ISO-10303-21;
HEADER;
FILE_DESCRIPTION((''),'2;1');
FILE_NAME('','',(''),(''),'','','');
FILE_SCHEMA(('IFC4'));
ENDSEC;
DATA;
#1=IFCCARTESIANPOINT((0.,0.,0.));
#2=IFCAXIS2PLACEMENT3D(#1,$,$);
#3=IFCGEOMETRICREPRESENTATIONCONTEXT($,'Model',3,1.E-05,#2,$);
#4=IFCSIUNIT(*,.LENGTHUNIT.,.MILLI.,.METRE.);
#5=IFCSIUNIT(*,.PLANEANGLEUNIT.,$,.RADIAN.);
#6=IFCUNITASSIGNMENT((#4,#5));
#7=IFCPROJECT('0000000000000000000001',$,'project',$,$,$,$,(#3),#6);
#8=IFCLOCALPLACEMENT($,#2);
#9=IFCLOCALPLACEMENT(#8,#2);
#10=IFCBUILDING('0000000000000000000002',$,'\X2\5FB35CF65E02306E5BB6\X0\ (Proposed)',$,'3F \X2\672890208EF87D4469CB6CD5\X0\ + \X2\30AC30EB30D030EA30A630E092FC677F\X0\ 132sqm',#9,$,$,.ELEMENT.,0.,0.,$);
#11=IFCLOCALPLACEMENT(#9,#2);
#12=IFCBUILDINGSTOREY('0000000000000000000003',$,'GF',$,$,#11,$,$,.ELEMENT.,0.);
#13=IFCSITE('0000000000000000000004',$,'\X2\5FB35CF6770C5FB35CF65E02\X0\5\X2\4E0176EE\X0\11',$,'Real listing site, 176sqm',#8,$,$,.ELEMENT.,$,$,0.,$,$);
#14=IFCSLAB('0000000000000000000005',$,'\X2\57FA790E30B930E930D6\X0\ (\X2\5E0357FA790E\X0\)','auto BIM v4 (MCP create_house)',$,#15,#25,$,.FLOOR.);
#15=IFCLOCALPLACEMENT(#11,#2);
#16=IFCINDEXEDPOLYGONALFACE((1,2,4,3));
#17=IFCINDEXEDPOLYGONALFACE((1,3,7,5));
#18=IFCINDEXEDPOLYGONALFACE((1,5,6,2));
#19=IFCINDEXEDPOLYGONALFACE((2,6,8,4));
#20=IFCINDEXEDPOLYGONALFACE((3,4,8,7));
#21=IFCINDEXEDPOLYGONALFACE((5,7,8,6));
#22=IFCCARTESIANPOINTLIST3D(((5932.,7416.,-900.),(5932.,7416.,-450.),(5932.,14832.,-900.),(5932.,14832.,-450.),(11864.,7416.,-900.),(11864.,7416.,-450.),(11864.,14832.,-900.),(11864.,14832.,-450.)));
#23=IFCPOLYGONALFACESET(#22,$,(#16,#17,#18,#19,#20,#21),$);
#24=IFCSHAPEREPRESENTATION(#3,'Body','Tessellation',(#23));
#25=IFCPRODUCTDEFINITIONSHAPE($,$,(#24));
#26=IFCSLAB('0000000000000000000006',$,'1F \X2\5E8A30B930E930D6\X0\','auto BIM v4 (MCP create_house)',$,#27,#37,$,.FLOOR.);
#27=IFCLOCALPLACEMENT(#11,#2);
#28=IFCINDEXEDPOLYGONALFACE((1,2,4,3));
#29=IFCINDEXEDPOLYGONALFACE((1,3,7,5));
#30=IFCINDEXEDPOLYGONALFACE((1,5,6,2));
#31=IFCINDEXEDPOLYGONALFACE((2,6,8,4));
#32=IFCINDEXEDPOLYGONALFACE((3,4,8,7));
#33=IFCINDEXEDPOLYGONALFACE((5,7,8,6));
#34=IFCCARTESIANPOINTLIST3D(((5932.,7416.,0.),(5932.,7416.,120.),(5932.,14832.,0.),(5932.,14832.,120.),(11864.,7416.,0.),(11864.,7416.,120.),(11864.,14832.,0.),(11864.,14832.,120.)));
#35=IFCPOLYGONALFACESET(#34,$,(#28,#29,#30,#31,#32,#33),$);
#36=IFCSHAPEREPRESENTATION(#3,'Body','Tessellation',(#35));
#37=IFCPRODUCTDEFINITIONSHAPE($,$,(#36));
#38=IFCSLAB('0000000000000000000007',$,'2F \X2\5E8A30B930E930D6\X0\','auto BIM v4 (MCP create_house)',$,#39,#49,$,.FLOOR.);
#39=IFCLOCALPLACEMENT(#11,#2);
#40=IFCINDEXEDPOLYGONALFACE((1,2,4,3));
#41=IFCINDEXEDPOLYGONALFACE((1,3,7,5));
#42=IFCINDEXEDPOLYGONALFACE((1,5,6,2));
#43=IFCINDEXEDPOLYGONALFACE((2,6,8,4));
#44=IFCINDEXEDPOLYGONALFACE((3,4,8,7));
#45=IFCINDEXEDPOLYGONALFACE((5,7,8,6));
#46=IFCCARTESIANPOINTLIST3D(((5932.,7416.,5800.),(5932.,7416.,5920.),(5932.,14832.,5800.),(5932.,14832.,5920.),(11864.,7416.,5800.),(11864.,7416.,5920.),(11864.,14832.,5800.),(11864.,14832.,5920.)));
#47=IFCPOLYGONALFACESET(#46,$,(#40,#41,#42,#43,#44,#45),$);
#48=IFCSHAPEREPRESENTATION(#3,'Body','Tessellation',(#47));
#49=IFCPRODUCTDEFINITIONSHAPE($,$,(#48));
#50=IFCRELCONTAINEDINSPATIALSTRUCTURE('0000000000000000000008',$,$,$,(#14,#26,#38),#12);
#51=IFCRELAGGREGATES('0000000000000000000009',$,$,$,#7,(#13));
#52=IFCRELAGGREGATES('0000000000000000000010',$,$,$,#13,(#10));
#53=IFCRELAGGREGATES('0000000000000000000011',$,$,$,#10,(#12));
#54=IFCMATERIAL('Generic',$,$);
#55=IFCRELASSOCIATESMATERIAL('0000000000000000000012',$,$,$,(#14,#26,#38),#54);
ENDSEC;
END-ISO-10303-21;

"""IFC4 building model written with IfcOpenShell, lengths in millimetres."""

from ifc_helpers import new_model, si_unit, frame, frame_2d, origin, place, context, project, spatial, rectangle, extrude, material, element, save


model = new_model("IFC4")

# Units and contexts
model_context = context("Model", 3, precision=1e-05, world=origin())
ifc_project = project(units=[si_unit("LENGTHUNIT", "METRE", prefix="MILLI"), si_unit("PLANEANGLEUNIT", "RADIAN")], contexts=[model_context])

# Site, building, storey
site_placement = place(None, origin())
site = spatial("IfcSite", under=ifc_project, at=site_placement, Name="徳島県徳島市5丁目11", ObjectType="Real listing site, 176sqm", CompositionType="ELEMENT", RefElevation=0.0)
building_placement = place(site_placement, origin())
building = spatial("IfcBuilding", under=site, at=building_placement, Name="徳島市の家 (Proposed)", ObjectType="3F 木造軸組構法 + ガルバリウム鋼板 132sqm", CompositionType="ELEMENT", ElevationOfRefHeight=0.0, ElevationOfTerrain=0.0)
storey_placement = place(building_placement, origin())
storey = spatial("IfcBuildingStorey", under=building, at=storey_placement, Name="GF", CompositionType="ELEMENT", Elevation=0.0)

# Slabs
ifc_material = material(Name="Generic")
slab_1_placement = place(storey_placement, frame((2966.0, 3708.0, -450.0)))
element("IfcSlab", 1, at=slab_1_placement, inside=storey, material=ifc_material, Name="基礎スラブ (布基礎)", Description="auto BIM v4 (MCP create_house)", PredefinedType="FLOOR", context=model_context, shape_type="SweptSolid", body=[
    extrude(rectangle(XDim=5932.0, YDim=7416.0, at=frame_2d((2966.0, 3708.0))), frame((2966.0, 3708.0, -450.0)), (0.0, 0.0, 1.0), 450.0),
])
slab_2_placement = place(storey_placement, frame((2966.0, 3708.0, 0.0)))
element("IfcSlab", 2, at=slab_2_placement, inside=storey, material=ifc_material, Name="1F 床スラブ", Description="auto BIM v4 (MCP create_house)", PredefinedType="FLOOR", context=model_context, shape_type="SweptSolid", body=[
    extrude(rectangle(XDim=5932.0, YDim=7416.0, at=frame_2d((2966.0, 3708.0))), frame((2966.0, 3708.0, 0.0)), (0.0, 0.0, 1.0), 120.0),
])
slab_3_placement = place(storey_placement, frame((2966.0, 3708.0, 2900.0)))
element("IfcSlab", 3, at=slab_3_placement, inside=storey, material=ifc_material, Name="2F 床スラブ", Description="auto BIM v4 (MCP create_house)", PredefinedType="FLOOR", context=model_context, shape_type="SweptSolid", body=[
    extrude(rectangle(XDim=5932.0, YDim=7416.0, at=frame_2d((2966.0, 3708.0))), frame((2966.0, 3708.0, 2900.0)), (0.0, 0.0, 1.0), 120.0),
])

save(model, "model.ifc")
